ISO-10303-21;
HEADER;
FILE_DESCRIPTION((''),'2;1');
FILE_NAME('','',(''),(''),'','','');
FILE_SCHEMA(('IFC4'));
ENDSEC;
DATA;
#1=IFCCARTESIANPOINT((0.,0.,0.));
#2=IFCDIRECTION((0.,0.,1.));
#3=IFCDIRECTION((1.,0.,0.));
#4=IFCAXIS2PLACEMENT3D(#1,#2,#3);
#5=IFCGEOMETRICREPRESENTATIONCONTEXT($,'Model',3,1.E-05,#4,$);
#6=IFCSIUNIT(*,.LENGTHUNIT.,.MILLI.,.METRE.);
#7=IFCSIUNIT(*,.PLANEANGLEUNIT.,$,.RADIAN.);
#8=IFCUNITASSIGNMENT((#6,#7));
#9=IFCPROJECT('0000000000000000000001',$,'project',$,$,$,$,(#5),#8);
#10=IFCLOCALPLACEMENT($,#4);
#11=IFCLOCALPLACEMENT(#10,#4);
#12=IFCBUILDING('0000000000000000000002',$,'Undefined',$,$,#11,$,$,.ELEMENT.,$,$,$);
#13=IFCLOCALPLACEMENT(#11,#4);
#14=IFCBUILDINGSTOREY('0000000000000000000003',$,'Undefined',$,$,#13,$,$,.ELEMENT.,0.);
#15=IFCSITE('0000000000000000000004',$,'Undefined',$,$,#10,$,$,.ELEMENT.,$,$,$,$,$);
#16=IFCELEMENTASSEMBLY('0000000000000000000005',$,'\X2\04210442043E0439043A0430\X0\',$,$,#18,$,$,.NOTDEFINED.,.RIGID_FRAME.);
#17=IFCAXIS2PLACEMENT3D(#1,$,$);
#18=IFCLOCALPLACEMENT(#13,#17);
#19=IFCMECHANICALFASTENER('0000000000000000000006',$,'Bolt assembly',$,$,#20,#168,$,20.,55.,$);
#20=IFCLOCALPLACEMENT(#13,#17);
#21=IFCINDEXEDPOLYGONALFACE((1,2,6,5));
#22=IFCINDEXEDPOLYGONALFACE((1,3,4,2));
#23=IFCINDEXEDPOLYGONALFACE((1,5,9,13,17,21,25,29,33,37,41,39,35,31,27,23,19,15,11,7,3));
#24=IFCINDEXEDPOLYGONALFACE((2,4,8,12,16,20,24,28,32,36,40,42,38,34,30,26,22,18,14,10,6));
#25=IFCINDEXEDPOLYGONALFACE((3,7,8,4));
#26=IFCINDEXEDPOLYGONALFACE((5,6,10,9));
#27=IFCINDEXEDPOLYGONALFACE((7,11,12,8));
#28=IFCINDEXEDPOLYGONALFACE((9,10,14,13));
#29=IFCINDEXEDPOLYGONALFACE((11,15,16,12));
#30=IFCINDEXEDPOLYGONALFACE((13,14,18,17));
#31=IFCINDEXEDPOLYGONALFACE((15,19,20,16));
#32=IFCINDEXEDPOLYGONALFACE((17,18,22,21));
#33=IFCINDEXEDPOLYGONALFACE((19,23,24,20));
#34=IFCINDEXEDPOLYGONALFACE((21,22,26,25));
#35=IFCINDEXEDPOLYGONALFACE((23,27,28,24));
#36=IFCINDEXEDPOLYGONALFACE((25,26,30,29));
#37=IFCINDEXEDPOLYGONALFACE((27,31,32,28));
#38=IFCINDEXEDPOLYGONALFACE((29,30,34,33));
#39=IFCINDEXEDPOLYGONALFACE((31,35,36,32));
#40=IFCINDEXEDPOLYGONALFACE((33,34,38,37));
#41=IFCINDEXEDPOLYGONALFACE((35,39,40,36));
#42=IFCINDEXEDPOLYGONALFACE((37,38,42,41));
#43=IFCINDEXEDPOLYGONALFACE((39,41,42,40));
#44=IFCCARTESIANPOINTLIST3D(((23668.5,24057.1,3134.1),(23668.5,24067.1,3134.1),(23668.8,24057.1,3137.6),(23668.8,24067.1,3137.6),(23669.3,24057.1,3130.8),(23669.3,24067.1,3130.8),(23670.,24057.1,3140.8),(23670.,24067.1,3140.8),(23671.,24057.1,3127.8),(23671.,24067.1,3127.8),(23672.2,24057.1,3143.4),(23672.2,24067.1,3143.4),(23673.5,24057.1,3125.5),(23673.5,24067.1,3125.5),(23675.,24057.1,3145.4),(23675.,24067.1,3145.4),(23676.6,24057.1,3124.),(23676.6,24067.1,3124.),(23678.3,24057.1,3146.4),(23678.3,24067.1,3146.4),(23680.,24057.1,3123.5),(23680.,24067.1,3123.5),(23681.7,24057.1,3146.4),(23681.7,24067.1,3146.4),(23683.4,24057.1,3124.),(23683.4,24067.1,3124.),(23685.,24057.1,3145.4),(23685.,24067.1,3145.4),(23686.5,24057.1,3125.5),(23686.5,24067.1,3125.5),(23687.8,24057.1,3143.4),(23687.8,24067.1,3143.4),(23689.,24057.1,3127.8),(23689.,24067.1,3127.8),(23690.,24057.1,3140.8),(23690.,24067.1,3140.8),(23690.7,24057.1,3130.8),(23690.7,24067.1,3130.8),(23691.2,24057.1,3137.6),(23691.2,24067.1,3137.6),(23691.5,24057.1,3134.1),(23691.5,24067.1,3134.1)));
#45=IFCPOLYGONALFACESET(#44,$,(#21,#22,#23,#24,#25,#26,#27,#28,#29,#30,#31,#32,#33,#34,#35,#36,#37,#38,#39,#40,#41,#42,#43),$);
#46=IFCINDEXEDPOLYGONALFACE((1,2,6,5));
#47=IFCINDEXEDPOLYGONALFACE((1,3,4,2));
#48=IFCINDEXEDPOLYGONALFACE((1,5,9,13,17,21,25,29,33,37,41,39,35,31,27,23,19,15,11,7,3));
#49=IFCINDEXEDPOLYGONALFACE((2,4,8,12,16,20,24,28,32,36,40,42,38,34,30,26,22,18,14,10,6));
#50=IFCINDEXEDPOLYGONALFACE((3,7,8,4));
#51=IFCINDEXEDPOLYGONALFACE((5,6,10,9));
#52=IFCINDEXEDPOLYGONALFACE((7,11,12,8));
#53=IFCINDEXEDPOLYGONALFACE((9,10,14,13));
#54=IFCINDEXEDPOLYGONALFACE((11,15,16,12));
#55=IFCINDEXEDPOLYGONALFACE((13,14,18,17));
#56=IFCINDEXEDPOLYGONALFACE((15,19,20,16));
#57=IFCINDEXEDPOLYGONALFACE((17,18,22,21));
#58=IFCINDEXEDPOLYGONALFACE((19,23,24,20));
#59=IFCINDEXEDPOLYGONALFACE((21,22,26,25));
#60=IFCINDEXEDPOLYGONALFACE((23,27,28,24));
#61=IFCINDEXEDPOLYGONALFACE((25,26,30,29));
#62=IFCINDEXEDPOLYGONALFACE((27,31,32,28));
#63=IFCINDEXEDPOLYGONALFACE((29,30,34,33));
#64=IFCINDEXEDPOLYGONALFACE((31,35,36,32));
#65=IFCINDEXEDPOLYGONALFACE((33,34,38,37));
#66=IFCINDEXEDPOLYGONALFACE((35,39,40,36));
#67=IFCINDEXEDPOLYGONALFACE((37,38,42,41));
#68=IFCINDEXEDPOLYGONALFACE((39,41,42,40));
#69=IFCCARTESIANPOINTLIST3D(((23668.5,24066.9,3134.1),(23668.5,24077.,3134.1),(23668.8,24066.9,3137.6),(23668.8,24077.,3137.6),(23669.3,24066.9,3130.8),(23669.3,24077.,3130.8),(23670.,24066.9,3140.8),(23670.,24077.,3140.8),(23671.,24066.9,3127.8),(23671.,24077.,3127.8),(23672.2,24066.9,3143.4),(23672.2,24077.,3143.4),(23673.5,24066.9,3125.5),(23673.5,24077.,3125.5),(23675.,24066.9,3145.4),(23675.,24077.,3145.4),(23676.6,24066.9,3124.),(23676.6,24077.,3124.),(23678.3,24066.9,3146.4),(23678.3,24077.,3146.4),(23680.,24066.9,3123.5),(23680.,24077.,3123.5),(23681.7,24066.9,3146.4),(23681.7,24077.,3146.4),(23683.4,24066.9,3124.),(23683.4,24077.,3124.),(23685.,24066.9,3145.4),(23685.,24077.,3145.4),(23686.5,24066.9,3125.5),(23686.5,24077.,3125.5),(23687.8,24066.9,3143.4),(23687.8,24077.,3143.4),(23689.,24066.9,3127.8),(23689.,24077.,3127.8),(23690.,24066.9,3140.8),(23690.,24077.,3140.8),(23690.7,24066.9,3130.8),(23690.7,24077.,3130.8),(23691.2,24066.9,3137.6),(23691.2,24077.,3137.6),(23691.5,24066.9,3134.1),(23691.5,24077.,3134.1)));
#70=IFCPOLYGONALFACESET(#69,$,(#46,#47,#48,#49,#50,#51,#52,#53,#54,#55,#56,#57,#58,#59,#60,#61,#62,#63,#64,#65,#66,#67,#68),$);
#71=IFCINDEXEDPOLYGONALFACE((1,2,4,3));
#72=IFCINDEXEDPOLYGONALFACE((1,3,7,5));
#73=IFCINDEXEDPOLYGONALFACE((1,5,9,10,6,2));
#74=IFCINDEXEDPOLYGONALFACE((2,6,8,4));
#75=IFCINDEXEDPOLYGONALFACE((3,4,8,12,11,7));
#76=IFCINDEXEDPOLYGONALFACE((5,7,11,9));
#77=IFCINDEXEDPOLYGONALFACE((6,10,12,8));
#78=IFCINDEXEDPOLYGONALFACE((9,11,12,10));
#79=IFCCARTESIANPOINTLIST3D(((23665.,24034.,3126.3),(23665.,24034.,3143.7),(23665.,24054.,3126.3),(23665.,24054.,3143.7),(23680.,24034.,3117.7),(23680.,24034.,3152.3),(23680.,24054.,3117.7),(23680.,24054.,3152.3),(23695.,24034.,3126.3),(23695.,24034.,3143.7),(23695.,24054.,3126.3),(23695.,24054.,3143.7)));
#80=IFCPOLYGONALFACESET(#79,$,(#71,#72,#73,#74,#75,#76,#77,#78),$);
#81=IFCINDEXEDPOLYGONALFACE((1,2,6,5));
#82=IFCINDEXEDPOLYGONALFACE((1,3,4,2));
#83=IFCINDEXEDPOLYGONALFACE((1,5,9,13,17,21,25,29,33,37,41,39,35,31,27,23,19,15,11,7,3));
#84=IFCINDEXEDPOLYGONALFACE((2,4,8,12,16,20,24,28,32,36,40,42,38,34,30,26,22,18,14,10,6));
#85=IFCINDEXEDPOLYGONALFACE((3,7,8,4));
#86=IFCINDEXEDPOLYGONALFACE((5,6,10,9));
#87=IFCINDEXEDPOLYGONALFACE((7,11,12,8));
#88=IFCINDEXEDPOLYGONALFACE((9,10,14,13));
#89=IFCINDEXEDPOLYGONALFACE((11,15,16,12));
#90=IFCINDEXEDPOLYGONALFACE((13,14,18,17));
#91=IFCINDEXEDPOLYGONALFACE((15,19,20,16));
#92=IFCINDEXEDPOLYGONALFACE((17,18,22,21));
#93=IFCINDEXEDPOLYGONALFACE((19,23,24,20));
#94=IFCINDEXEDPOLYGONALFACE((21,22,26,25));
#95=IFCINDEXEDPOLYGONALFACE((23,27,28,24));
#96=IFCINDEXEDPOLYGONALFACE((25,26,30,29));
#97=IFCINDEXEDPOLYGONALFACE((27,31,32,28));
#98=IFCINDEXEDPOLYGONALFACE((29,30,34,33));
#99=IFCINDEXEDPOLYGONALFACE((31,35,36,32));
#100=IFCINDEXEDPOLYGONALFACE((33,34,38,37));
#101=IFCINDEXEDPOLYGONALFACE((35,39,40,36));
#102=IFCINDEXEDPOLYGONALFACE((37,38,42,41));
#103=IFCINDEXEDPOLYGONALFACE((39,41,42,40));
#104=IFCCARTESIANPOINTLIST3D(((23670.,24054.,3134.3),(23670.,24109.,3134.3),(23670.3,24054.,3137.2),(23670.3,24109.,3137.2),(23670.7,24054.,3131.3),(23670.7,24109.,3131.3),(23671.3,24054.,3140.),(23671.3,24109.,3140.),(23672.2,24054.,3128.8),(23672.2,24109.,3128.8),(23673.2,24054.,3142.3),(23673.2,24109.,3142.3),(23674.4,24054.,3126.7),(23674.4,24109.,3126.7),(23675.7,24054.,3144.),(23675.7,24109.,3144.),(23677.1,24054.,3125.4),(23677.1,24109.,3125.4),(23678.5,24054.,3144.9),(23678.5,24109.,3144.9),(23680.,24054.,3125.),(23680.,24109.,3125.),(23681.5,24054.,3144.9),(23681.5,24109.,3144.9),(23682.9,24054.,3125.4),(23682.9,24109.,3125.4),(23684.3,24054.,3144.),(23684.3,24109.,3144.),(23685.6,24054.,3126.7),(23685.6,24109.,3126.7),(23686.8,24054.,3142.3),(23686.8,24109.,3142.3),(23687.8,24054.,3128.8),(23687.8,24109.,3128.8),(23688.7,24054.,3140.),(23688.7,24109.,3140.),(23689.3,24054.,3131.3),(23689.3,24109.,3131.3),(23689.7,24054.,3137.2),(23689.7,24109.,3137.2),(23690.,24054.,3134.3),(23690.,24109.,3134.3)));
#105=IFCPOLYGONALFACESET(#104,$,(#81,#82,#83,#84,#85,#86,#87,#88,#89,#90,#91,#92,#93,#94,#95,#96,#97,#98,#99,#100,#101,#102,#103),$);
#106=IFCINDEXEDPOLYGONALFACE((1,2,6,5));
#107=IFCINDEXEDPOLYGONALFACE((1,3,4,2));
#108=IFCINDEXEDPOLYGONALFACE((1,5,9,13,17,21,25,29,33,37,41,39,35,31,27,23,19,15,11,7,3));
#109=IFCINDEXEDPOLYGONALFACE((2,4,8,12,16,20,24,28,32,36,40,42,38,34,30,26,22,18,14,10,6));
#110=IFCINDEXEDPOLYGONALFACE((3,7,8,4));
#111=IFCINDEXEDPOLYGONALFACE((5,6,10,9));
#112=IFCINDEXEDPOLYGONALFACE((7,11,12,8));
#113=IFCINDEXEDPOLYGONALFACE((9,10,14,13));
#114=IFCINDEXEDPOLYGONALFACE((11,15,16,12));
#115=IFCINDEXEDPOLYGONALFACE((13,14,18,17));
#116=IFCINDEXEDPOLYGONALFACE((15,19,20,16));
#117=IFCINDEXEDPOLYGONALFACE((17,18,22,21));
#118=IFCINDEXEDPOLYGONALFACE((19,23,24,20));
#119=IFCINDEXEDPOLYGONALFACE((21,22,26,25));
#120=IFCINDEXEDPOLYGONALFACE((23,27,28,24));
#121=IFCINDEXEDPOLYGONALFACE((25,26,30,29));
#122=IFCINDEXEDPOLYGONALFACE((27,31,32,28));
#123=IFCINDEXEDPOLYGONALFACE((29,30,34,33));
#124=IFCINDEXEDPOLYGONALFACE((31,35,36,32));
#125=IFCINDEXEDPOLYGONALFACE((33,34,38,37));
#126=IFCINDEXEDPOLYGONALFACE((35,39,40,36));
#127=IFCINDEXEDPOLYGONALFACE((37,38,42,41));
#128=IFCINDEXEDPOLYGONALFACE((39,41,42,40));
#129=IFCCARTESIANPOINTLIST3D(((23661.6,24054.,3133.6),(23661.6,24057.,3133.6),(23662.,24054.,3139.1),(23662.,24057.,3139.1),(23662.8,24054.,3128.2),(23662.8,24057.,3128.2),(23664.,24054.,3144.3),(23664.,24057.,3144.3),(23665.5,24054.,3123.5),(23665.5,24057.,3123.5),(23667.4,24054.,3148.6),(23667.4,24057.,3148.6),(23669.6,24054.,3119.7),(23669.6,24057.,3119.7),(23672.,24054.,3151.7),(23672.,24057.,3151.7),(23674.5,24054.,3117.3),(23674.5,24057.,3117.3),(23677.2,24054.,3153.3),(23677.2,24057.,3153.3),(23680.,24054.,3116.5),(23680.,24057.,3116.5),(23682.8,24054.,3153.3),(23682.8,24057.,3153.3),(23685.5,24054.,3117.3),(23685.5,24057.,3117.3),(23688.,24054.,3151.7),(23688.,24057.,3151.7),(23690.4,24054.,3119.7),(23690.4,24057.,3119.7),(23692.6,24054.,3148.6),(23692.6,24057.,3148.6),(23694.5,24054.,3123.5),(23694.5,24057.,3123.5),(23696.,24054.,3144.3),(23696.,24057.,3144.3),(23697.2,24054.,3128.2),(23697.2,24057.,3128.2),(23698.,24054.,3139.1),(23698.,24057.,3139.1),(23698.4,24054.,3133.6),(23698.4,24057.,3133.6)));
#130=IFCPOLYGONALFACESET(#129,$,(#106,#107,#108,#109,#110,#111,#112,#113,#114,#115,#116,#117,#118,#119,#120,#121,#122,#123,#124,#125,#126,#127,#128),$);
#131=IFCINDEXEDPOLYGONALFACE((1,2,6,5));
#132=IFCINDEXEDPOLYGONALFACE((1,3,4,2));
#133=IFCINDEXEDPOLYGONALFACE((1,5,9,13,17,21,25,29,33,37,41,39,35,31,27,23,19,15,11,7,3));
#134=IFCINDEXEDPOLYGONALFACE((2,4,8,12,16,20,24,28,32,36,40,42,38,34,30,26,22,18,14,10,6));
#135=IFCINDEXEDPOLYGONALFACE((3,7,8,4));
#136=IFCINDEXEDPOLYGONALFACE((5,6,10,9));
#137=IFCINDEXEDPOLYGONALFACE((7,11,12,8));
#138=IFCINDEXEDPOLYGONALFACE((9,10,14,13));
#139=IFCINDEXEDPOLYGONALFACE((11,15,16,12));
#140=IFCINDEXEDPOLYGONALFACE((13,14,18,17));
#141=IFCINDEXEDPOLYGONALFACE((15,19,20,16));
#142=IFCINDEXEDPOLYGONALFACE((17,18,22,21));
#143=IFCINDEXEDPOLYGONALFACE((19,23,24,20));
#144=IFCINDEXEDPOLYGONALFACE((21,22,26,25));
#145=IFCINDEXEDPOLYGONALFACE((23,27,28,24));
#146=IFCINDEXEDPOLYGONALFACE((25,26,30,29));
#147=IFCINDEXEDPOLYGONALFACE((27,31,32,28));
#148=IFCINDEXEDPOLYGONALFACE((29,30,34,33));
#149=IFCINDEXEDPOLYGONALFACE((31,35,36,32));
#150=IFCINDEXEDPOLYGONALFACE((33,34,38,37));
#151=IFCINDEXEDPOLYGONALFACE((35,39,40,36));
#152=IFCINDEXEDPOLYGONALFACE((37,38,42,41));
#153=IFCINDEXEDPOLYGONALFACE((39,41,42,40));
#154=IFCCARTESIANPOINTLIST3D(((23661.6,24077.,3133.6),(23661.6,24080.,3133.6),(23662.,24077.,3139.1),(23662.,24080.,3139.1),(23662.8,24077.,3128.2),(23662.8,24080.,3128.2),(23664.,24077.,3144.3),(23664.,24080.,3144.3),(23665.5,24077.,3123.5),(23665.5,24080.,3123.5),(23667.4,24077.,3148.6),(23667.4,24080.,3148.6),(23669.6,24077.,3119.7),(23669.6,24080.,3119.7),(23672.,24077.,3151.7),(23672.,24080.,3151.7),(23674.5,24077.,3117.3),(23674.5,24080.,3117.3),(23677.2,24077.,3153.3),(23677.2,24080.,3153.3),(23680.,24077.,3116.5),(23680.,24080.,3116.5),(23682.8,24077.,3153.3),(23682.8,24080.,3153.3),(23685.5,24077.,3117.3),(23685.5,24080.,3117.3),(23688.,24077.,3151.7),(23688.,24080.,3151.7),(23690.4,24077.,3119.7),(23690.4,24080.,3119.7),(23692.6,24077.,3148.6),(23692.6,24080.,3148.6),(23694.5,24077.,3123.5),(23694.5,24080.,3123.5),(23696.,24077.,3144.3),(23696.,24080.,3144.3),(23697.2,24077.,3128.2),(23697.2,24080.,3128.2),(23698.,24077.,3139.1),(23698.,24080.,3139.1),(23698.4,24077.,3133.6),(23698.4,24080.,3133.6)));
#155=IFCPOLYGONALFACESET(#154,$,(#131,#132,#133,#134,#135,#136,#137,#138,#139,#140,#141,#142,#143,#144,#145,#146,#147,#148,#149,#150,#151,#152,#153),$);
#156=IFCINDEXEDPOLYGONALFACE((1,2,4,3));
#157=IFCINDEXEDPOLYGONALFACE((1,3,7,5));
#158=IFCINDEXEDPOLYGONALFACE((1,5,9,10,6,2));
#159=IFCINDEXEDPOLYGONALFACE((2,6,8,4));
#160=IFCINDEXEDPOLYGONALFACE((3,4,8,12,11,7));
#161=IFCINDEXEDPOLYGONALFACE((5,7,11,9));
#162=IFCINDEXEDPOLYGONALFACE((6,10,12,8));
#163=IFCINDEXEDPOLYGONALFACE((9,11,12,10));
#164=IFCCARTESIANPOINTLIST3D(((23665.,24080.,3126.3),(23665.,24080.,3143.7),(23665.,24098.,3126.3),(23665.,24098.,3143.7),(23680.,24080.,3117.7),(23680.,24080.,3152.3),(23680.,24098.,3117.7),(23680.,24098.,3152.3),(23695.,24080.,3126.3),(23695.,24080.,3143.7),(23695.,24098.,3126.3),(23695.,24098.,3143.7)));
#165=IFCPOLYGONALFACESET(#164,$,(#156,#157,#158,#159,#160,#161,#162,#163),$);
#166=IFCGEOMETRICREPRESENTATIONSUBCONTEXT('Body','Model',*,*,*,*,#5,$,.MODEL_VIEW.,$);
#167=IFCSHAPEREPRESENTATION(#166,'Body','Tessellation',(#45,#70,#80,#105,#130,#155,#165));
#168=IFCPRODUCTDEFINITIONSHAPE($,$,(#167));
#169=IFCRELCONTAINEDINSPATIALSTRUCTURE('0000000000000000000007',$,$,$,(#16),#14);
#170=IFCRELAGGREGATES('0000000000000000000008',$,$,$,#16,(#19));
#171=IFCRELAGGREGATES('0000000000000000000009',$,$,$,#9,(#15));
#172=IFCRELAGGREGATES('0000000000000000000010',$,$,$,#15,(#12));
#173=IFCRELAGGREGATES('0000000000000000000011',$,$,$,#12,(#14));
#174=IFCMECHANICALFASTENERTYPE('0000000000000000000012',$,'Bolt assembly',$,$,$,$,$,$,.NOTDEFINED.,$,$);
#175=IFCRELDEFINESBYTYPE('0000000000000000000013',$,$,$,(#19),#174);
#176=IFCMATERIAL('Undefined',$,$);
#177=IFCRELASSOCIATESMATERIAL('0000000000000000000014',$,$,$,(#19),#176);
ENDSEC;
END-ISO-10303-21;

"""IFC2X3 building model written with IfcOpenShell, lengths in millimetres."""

from ifc_helpers import new_model, si_unit, frame, origin_with_axes, origin_2d_with_axis, place, context, subcontext, project, spatial, polyline, circle, outline, extrude, source, transform, mapped, material, type_object, element, aggregate, save


model = new_model("IFC2X3")

# Units and contexts
model_context = context("Model", 3, precision=1e-05, world=origin_with_axes())
body_context = subcontext(model_context, "Body", "Model", "MODEL_VIEW")
ifc_project = project(units=[si_unit("LENGTHUNIT", "METRE", prefix="MILLI"), si_unit("PLANEANGLEUNIT", "RADIAN")], contexts=[model_context])

# Site, building, storey
site_placement = place(None, origin_with_axes())
site = spatial("IfcSite", under=ifc_project, at=site_placement, Name="Undefined", CompositionType="ELEMENT")
building_placement = place(site_placement, origin_with_axes())
building = spatial("IfcBuilding", under=site, at=building_placement, Name="Undefined", CompositionType="ELEMENT")
storey_placement = place(building_placement, origin_with_axes())
storey = spatial("IfcBuildingStorey", under=building, at=storey_placement, Name="Undefined", CompositionType="ELEMENT", Elevation=0.0)

# Element assembly
assembly_1_placement = place(storey_placement, origin_with_axes())
assembly_1 = element("IfcElementAssembly", 1, at=assembly_1_placement, inside=storey, Name="Стойка", AssemblyPlace="NOTDEFINED", PredefinedType="RIGID_FRAME")

# Mechanical fastener
ifc_material_1 = material(Name="Undefined")
mechanical_fastener_type = type_object("IfcMechanicalFastenerType", Name="Bolt assembly")
shared_shape = source(origin_with_axes(), body_context, "Body", "SweptSolid", [
    extrude(circle(Radius=11.5, at=origin_2d_with_axis()), frame((0.0, 0.1, 0.0), z_axis=(0.0, 1.0, 0.0), x_axis=(1.0, 0.0, 0.0)), (0.0, 0.0, 1.0), 10.0),
    extrude(circle(Radius=11.5, at=origin_2d_with_axis()), frame((0.0, 9.9, 0.0), z_axis=(0.0, 1.0, 0.0), x_axis=(1.0, 0.0, 0.0)), (0.0, 0.0, 1.0), 10.1),
    extrude(outline(polyline([(17.3, 0.0), (8.7, 15.0), (-8.7, 15.0), (-17.3, 0.0), (-8.7, -15.0), (8.7, -15.0), (17.3, 0.0)])), frame((0.0, -23.0, 0.0), z_axis=(0.0, 1.0, 0.0), x_axis=(1.0, 0.0, 0.0)), (0.0, 0.0, 1.0), 20.0),
    extrude(circle(Radius=10.0, at=origin_2d_with_axis()), frame((0.0, -3.0, 0.0), z_axis=(0.0, 1.0, 0.0), x_axis=(1.0, 0.0, 0.0)), (0.0, 0.0, 1.0), 55.0),
    extrude(circle(Radius=18.5, at=origin_2d_with_axis()), frame((0.0, -3.0, 0.0), z_axis=(0.0, 1.0, 0.0), x_axis=(1.0, 0.0, 0.0)), (0.0, 0.0, 1.0), 3.0),
    extrude(circle(Radius=18.5, at=origin_2d_with_axis()), frame((0.0, 20.0, 0.0), z_axis=(0.0, 1.0, 0.0), x_axis=(1.0, 0.0, 0.0)), (0.0, 0.0, 1.0), 3.0),
    extrude(outline(polyline([(17.3, 0.0), (8.7, 15.0), (-8.7, 15.0), (-17.3, 0.0), (-8.7, -15.0), (8.7, -15.0), (17.3, 0.0)])), frame((0.0, 23.0, 0.0), z_axis=(0.0, 1.0, 0.0), x_axis=(1.0, 0.0, 0.0)), (0.0, 0.0, 1.0), 18.0),
])
mechanical_fastener_1_placement = place(assembly_1_placement, frame((23680.0, 24057.0, 3135.0), z_axis=(1.0, 0.0, 0.0), x_axis=(0.0, 0.0, -1.0)))
mechanical_fastener_1 = element("IfcMechanicalFastener", 2, at=mechanical_fastener_1_placement, type_object=mechanical_fastener_type, material=ifc_material_1, Name="Bolt assembly", NominalDiameter=20.0, NominalLength=55.0, context=body_context, shape_type="MappedRepresentation", body=[
    mapped(shared_shape, transform((0.0, 0.0, 0.0))),
])
aggregate(assembly_1, [mechanical_fastener_1])

save(model, "model.ifc")
